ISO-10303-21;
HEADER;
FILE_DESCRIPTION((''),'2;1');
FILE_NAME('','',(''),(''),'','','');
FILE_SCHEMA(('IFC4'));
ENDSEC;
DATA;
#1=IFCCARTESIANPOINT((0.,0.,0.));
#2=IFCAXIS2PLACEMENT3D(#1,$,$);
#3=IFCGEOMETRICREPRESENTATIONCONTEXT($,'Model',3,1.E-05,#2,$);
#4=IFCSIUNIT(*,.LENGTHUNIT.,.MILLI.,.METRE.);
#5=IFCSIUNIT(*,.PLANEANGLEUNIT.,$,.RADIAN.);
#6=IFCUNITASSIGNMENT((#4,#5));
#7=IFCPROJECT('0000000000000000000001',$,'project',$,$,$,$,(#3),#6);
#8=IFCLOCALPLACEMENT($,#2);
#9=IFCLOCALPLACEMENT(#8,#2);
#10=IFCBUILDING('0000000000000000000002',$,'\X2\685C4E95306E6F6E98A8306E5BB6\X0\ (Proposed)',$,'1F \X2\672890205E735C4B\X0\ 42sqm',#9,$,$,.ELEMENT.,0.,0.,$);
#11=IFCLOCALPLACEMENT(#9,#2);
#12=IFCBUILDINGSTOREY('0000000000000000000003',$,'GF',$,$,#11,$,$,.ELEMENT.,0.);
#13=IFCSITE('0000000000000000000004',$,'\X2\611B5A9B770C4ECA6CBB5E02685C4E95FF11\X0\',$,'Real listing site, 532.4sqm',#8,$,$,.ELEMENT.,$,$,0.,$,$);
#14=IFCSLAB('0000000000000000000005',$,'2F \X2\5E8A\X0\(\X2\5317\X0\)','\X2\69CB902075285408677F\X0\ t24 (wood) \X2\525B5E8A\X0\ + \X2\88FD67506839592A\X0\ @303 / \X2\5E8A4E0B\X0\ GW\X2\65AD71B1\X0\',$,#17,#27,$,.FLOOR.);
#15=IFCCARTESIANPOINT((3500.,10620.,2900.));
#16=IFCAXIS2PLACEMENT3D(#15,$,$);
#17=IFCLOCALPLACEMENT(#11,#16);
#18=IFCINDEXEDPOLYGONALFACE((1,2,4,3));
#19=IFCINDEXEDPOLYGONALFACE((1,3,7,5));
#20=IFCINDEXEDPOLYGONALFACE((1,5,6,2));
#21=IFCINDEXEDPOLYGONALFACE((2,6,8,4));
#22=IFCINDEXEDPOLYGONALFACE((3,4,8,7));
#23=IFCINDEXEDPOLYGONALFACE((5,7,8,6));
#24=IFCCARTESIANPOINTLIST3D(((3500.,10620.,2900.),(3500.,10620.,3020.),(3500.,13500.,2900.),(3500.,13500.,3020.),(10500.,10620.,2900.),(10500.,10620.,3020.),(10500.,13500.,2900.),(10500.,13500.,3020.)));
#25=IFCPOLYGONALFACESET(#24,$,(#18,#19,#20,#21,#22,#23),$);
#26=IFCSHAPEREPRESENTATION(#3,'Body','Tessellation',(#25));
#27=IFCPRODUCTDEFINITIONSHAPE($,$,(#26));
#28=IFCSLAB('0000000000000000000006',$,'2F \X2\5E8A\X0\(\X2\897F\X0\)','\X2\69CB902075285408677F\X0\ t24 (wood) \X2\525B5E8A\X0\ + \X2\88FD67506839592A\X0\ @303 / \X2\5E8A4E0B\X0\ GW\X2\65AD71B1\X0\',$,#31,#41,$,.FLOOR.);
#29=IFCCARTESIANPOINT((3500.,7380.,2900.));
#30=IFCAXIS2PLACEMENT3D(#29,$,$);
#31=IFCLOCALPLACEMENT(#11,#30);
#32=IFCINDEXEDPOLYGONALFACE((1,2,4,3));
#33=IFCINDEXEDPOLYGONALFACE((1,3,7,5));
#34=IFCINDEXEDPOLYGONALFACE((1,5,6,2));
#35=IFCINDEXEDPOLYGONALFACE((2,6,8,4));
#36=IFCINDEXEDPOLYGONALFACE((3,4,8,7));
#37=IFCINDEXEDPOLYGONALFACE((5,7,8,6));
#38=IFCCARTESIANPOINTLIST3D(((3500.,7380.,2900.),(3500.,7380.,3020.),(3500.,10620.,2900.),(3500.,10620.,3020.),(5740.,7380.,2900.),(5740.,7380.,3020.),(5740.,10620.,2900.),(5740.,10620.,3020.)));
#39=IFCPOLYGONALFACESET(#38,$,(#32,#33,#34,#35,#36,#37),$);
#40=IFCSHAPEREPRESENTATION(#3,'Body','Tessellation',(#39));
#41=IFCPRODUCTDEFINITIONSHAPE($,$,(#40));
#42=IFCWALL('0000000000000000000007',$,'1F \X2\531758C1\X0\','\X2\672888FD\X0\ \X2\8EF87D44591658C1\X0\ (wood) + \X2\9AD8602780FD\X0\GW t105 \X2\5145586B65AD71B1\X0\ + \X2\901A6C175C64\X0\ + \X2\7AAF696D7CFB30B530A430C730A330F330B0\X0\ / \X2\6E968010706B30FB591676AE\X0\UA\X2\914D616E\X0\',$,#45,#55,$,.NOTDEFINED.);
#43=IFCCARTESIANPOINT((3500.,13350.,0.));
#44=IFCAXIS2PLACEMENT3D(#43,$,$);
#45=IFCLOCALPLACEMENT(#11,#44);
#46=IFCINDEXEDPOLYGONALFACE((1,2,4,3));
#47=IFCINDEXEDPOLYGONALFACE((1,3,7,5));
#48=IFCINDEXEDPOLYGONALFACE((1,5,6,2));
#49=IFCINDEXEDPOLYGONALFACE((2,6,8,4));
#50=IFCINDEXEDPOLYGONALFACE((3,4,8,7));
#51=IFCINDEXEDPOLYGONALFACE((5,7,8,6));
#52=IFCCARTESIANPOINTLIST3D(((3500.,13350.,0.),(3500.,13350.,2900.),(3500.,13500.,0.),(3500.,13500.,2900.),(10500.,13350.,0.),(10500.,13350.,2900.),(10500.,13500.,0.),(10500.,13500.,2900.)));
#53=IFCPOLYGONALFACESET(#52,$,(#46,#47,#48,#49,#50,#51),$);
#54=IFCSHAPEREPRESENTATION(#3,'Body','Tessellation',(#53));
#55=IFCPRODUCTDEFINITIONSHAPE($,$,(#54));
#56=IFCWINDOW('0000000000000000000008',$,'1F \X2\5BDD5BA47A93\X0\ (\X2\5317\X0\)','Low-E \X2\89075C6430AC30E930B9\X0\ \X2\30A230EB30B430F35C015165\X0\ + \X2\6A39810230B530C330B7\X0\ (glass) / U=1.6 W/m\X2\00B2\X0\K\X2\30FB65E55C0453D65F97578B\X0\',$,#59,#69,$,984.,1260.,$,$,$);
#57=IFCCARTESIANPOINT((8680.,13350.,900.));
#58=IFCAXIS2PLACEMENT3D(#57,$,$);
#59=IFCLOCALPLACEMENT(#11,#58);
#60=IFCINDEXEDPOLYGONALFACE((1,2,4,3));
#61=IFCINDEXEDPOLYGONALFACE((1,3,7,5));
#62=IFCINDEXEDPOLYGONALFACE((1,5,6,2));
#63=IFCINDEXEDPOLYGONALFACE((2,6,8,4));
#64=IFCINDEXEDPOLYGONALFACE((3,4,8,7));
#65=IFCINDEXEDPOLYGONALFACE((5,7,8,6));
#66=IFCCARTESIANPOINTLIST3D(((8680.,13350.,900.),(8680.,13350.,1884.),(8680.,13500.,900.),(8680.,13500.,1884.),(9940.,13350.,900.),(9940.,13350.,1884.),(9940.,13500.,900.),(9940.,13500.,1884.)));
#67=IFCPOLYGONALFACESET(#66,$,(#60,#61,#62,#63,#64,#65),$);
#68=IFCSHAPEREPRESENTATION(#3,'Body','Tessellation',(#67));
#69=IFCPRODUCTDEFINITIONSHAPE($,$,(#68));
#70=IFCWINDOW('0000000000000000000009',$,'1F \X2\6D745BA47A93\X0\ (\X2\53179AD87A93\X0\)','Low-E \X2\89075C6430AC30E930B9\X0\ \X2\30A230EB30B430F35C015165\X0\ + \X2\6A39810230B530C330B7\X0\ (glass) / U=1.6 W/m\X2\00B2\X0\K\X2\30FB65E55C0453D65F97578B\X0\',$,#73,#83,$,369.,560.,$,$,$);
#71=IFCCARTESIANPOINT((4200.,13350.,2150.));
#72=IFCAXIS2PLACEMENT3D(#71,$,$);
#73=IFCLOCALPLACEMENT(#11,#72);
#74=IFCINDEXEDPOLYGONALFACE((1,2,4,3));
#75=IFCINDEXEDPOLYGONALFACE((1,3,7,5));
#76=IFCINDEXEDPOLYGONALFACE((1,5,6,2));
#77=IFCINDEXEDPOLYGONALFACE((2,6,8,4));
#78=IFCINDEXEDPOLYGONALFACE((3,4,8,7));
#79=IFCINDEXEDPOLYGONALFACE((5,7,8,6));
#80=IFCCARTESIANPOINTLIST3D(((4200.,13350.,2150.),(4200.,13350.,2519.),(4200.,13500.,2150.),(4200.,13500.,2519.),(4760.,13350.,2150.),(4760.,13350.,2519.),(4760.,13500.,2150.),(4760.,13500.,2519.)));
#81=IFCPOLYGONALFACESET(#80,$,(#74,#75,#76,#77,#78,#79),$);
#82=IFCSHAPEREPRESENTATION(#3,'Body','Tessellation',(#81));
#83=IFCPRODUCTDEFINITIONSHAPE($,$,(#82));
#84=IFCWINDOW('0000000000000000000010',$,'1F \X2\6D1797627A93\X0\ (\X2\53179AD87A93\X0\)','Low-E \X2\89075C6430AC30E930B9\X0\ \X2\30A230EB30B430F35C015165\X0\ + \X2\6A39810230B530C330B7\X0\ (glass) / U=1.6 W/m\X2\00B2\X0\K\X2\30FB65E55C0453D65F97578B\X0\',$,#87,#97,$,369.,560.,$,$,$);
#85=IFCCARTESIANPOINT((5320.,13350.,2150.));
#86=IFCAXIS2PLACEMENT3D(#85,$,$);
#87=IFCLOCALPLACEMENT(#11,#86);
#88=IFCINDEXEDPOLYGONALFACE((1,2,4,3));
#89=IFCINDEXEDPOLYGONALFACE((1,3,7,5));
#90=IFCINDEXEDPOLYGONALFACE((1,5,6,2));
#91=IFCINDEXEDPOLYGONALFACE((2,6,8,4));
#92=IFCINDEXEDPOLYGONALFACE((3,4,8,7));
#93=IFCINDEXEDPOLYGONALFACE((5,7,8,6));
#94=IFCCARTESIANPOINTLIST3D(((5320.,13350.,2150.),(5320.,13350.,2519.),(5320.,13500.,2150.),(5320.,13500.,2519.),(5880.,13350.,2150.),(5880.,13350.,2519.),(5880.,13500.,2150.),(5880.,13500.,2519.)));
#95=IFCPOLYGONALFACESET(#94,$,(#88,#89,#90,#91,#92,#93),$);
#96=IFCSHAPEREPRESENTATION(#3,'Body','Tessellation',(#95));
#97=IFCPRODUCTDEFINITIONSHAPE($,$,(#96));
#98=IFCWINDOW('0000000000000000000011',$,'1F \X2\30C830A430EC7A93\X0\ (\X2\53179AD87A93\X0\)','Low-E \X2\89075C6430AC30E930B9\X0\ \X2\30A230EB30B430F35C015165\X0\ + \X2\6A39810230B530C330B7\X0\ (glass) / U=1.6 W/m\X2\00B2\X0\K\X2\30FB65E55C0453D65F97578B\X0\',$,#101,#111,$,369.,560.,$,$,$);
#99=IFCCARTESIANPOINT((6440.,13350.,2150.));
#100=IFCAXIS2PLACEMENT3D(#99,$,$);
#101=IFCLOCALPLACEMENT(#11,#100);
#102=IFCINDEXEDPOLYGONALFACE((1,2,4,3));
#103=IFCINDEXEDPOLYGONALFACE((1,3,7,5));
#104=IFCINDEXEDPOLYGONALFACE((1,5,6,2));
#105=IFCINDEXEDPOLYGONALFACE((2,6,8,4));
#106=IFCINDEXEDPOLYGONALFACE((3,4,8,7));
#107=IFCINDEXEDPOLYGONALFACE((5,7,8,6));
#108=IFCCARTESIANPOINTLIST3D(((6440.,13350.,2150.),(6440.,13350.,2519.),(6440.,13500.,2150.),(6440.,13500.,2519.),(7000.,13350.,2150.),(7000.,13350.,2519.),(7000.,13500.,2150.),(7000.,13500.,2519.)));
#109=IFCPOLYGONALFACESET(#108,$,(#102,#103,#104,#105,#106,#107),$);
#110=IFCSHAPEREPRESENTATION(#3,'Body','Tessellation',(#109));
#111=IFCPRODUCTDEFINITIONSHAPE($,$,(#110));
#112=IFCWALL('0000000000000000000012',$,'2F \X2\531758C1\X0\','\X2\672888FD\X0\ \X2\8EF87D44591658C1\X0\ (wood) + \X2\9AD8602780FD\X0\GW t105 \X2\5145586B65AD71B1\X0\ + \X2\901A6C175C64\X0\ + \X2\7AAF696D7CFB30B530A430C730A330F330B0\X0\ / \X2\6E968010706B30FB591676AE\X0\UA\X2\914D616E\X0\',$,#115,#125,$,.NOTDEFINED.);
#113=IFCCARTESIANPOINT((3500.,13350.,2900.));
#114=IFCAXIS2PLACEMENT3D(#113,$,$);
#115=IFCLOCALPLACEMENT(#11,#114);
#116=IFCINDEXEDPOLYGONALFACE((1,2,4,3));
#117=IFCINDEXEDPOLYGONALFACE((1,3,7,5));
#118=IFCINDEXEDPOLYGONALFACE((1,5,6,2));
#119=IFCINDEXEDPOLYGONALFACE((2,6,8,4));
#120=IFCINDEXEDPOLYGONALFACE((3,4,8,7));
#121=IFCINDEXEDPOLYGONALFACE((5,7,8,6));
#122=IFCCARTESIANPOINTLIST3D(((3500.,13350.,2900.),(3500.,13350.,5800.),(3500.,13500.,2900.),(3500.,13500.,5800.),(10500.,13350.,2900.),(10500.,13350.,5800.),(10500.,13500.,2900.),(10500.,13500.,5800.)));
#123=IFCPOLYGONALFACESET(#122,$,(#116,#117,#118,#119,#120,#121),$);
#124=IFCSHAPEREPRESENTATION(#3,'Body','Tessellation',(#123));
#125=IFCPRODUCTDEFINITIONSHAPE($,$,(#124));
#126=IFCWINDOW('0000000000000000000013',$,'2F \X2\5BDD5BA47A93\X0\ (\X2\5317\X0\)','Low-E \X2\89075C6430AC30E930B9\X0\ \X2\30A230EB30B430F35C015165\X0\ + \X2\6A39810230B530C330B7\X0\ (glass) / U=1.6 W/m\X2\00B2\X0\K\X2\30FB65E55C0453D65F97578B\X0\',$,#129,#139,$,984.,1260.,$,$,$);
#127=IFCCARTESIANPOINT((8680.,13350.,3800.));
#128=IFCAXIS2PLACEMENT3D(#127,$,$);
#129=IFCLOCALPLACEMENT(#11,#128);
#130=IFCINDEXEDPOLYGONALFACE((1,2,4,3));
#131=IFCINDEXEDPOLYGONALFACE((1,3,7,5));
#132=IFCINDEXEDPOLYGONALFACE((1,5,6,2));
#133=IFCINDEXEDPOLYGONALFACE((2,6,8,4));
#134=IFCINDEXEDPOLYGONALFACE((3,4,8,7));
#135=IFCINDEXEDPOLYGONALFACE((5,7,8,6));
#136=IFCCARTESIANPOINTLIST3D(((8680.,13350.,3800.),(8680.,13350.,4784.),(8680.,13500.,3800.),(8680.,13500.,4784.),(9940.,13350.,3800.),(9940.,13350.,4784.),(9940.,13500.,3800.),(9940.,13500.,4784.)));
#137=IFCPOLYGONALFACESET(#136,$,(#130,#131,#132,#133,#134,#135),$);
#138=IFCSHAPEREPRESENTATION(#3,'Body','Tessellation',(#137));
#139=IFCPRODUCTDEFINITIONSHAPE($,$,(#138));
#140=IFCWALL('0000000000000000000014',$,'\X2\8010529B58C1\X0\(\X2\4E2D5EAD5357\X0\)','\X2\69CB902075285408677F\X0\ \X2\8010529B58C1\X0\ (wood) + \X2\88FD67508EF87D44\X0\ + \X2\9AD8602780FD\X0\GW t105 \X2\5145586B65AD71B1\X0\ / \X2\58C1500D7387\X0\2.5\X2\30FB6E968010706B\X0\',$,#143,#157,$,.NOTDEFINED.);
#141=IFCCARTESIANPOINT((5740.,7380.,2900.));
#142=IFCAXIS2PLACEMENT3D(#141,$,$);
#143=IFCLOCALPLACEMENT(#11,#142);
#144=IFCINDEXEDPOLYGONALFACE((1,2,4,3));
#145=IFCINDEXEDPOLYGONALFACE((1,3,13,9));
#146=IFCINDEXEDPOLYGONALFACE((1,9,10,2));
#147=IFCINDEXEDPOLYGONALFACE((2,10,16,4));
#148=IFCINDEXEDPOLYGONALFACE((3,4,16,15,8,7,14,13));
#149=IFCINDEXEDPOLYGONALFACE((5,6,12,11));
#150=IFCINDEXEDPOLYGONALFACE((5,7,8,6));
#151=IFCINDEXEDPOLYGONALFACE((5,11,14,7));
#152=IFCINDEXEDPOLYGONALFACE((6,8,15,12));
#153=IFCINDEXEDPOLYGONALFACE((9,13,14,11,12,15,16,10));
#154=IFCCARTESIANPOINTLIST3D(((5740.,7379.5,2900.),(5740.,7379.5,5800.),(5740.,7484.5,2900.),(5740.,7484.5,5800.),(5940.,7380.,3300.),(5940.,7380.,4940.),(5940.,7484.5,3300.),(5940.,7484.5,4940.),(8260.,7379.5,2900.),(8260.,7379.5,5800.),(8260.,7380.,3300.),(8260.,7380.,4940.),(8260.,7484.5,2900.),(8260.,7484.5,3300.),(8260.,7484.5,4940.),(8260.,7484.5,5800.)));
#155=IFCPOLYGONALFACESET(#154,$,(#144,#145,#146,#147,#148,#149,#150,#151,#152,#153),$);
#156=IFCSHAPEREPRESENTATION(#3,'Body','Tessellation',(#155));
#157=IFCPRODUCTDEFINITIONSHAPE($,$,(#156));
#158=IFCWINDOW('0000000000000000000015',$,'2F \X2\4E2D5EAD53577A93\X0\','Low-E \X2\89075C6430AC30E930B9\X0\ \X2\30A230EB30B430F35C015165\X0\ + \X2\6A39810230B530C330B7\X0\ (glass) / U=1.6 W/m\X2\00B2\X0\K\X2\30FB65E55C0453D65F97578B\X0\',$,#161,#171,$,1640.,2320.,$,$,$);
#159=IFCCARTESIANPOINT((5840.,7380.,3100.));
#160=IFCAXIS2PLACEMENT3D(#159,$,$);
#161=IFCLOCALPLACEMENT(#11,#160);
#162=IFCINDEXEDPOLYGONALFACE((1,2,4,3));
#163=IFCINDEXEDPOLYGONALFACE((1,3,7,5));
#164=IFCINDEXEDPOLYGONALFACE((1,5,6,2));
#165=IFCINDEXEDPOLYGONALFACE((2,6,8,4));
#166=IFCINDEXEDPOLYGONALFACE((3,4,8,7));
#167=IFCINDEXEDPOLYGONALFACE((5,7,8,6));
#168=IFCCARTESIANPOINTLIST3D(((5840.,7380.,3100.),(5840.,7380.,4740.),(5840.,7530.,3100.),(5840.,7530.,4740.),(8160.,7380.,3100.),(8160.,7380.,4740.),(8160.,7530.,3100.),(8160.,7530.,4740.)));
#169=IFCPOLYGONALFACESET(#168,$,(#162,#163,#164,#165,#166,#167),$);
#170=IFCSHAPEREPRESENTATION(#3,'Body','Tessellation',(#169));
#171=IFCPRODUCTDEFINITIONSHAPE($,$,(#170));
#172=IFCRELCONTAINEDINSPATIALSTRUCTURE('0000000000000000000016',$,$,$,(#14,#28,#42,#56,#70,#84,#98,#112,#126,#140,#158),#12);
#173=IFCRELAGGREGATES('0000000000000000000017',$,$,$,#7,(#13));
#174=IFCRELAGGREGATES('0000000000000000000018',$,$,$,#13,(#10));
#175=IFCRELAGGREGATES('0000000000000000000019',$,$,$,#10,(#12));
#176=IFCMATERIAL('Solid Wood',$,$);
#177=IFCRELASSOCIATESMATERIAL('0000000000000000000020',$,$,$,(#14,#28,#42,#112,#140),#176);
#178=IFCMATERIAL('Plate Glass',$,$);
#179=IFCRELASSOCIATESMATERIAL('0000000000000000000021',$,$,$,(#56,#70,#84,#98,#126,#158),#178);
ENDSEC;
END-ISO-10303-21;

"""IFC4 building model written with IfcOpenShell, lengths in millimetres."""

from ifc_helpers import new_model, si_unit, frame, frame_2d, origin, place, context, project, spatial, rectangle, extrude, material, element, fill, save


model = new_model("IFC4")

# Units and contexts
model_context = context("Model", 3, precision=1e-05, world=origin())
ifc_project = project(units=[si_unit("LENGTHUNIT", "METRE", prefix="MILLI"), si_unit("PLANEANGLEUNIT", "RADIAN")], contexts=[model_context])

# Site, building, storey
site_placement = place(None, origin())
site = spatial("IfcSite", under=ifc_project, at=site_placement, Name="愛媛県今治市桜井１", ObjectType="Real listing site, 532.4sqm", CompositionType="ELEMENT", RefElevation=0.0)
building_placement = place(site_placement, origin())
building = spatial("IfcBuilding", under=site, at=building_placement, Name="桜井の潮風の家 (Proposed)", ObjectType="1F 木造平屋 42sqm", CompositionType="ELEMENT", ElevationOfRefHeight=0.0, ElevationOfTerrain=0.0)
storey_placement = place(building_placement, origin())
storey = spatial("IfcBuildingStorey", under=building, at=storey_placement, Name="GF", CompositionType="ELEMENT", Elevation=0.0)

# Slabs
ifc_material_1 = material(Name="Solid Wood")
slab_1_placement = place(storey_placement, frame((3500.0, 10620.0, 2900.0)))
element("IfcSlab", 1, at=slab_1_placement, inside=storey, material=ifc_material_1, Name="2F 床(北)", Description="構造用合板 t24 (wood) 剛床 + 製材根太 @303 / 床下 GW断熱", PredefinedType="FLOOR", context=model_context, shape_type="SweptSolid", body=[
    extrude(rectangle(XDim=7000.0, YDim=2880.0, at=frame_2d((3500.0, 1440.0))), frame((3500.0, 10620.0, 2900.0)), (0.0, 0.0, 1.0), 120.0),
])
slab_2_placement = place(storey_placement, frame((3500.0, 7380.0, 2900.0)))
element("IfcSlab", 2, at=slab_2_placement, inside=storey, material=ifc_material_1, Name="2F 床(西)", Description="構造用合板 t24 (wood) 剛床 + 製材根太 @303 / 床下 GW断熱", PredefinedType="FLOOR", context=model_context, shape_type="SweptSolid", body=[
    extrude(rectangle(XDim=2240.0, YDim=3240.0, at=frame_2d((1120.0, 1620.0))), frame((3500.0, 7380.0, 2900.0)), (0.0, 0.0, 1.0), 120.0),
])

# Wall, openings, windows
wall_1_placement = place(storey_placement, frame((3500.0, 13350.0, 0.0)))
wall_1 = element("IfcWall", 3, at=wall_1_placement, inside=storey, material=ifc_material_1, Name="1F 北壁", Description="木製 軸組外壁 (wood) + 高性能GW t105 充填断熱 + 通気層 + 窯業系サイディング / 準耐火・外皮UA配慮", PredefinedType="NOTDEFINED", context=model_context, shape_type="SweptSolid", body=[
    extrude(rectangle(XDim=7000.0, YDim=150.0, at=frame_2d((3500.0, 75.0))), frame((3500.0, 13350.0, 0.0)), (0.0, 0.0, 1.0), 2900.0),
])
opening_1_placement = place(storey_placement, frame((8680.0, 13350.0, 900.0)))
opening_1 = element("IfcOpeningElement", 4, at=opening_1_placement, cuts=wall_1, PredefinedType="NOTDEFINED", context=model_context, shape_type="SweptSolid", body=[
    extrude(rectangle(XDim=1260.0, YDim=150.0, at=frame_2d((630.0, 75.0))), frame((8680.0, 13350.0, 900.0)), (0.0, 0.0, 1.0), 984.0),
])
opening_2_placement = place(storey_placement, frame((4200.0, 13350.0, 2150.0)))
opening_2 = element("IfcOpeningElement", 5, at=opening_2_placement, cuts=wall_1, PredefinedType="NOTDEFINED", context=model_context, shape_type="SweptSolid", body=[
    extrude(rectangle(XDim=560.0, YDim=150.0, at=frame_2d((280.0, 75.0))), frame((4200.0, 13350.0, 2150.0)), (0.0, 0.0, 1.0), 369.0),
])
opening_3_placement = place(storey_placement, frame((5320.0, 13350.0, 2150.0)))
opening_3 = element("IfcOpeningElement", 6, at=opening_3_placement, cuts=wall_1, PredefinedType="NOTDEFINED", context=model_context, shape_type="SweptSolid", body=[
    extrude(rectangle(XDim=560.0, YDim=150.0, at=frame_2d((280.0, 75.0))), frame((5320.0, 13350.0, 2150.0)), (0.0, 0.0, 1.0), 369.0),
])
opening_4_placement = place(storey_placement, frame((6440.0, 13350.0, 2150.0)))
opening_4 = element("IfcOpeningElement", 7, at=opening_4_placement, cuts=wall_1, PredefinedType="NOTDEFINED", context=model_context, shape_type="SweptSolid", body=[
    extrude(rectangle(XDim=560.0, YDim=150.0, at=frame_2d((280.0, 75.0))), frame((6440.0, 13350.0, 2150.0)), (0.0, 0.0, 1.0), 369.0),
])
ifc_material_2 = material(Name="Plate Glass")
window_1_placement = place(storey_placement, frame((8680.0, 13350.0, 900.0)))
window_1 = element("IfcWindow", 8, at=window_1_placement, inside=storey, material=ifc_material_2, Name="1F 寝室窓 (北)", Description="Low-E 複層ガラス アルゴン封入 + 樹脂サッシ (glass) / U=1.6 W/m²K・日射取得型", OverallHeight=984.0, OverallWidth=1260.0, context=model_context, shape_type="SweptSolid", body=[
    extrude(rectangle(XDim=1260.0, YDim=150.0, at=frame_2d((630.0, 75.0))), frame((8680.0, 13350.0, 900.0)), (0.0, 0.0, 1.0), 984.0),
])
fill(opening_1, window_1)
window_2_placement = place(storey_placement, frame((4200.0, 13350.0, 2150.0)))
window_2 = element("IfcWindow", 9, at=window_2_placement, inside=storey, material=ifc_material_2, Name="1F 浴室窓 (北高窓)", Description="Low-E 複層ガラス アルゴン封入 + 樹脂サッシ (glass) / U=1.6 W/m²K・日射取得型", OverallHeight=369.0, OverallWidth=560.0, context=model_context, shape_type="SweptSolid", body=[
    extrude(rectangle(XDim=560.0, YDim=150.0, at=frame_2d((280.0, 75.0))), frame((4200.0, 13350.0, 2150.0)), (0.0, 0.0, 1.0), 369.0),
])
fill(opening_2, window_2)
window_3_placement = place(storey_placement, frame((5320.0, 13350.0, 2150.0)))
window_3 = element("IfcWindow", 10, at=window_3_placement, inside=storey, material=ifc_material_2, Name="1F 洗面窓 (北高窓)", Description="Low-E 複層ガラス アルゴン封入 + 樹脂サッシ (glass) / U=1.6 W/m²K・日射取得型", OverallHeight=369.0, OverallWidth=560.0, context=model_context, shape_type="SweptSolid", body=[
    extrude(rectangle(XDim=560.0, YDim=150.0, at=frame_2d((280.0, 75.0))), frame((5320.0, 13350.0, 2150.0)), (0.0, 0.0, 1.0), 369.0),
])
fill(opening_3, window_3)
window_4_placement = place(storey_placement, frame((6440.0, 13350.0, 2150.0)))
window_4 = element("IfcWindow", 11, at=window_4_placement, inside=storey, material=ifc_material_2, Name="1F トイレ窓 (北高窓)", Description="Low-E 複層ガラス アルゴン封入 + 樹脂サッシ (glass) / U=1.6 W/m²K・日射取得型", OverallHeight=369.0, OverallWidth=560.0, context=model_context, shape_type="SweptSolid", body=[
    extrude(rectangle(XDim=560.0, YDim=150.0, at=frame_2d((280.0, 75.0))), frame((6440.0, 13350.0, 2150.0)), (0.0, 0.0, 1.0), 369.0),
])
fill(opening_4, window_4)

# Walls, openings, windows
wall_2_placement = place(storey_placement, frame((3500.0, 13350.0, 2900.0)))
wall_2 = element("IfcWall", 12, at=wall_2_placement, inside=storey, material=ifc_material_1, Name="2F 北壁", Description="木製 軸組外壁 (wood) + 高性能GW t105 充填断熱 + 通気層 + 窯業系サイディング / 準耐火・外皮UA配慮", PredefinedType="NOTDEFINED", context=model_context, shape_type="SweptSolid", body=[
    extrude(rectangle(XDim=7000.0, YDim=150.0, at=frame_2d((3500.0, 75.0))), frame((3500.0, 13350.0, 2900.0)), (0.0, 0.0, 1.0), 2900.0),
])
opening_5_placement = place(storey_placement, frame((8680.0, 13350.0, 3800.0)))
opening_5 = element("IfcOpeningElement", 13, at=opening_5_placement, cuts=wall_2, PredefinedType="NOTDEFINED", context=model_context, shape_type="SweptSolid", body=[
    extrude(rectangle(XDim=1260.0, YDim=150.0, at=frame_2d((630.0, 75.0))), frame((8680.0, 13350.0, 3800.0)), (0.0, 0.0, 1.0), 984.0),
])
window_5_placement = place(storey_placement, frame((8680.0, 13350.0, 3800.0)))
window_5 = element("IfcWindow", 14, at=window_5_placement, inside=storey, material=ifc_material_2, Name="2F 寝室窓 (北)", Description="Low-E 複層ガラス アルゴン封入 + 樹脂サッシ (glass) / U=1.6 W/m²K・日射取得型", OverallHeight=984.0, OverallWidth=1260.0, context=model_context, shape_type="SweptSolid", body=[
    extrude(rectangle(XDim=1260.0, YDim=150.0, at=frame_2d((630.0, 75.0))), frame((8680.0, 13350.0, 3800.0)), (0.0, 0.0, 1.0), 984.0),
])
fill(opening_5, window_5)
wall_3_placement = place(storey_placement, frame((5740.0, 7380.0, 2900.0)))
wall_3 = element("IfcWall", 15, at=wall_3_placement, inside=storey, material=ifc_material_1, Name="耐力壁(中庭南)", Description="構造用合板 耐力壁 (wood) + 製材軸組 + 高性能GW t105 充填断熱 / 壁倍率2.5・準耐火", PredefinedType="NOTDEFINED", context=model_context, shape_type="SweptSolid", body=[
    extrude(rectangle(XDim=2520.0, YDim=105.0, at=frame_2d((1260.0, 52.0))), frame((5740.0, 7380.0, 2900.0)), (0.0, 0.0, 1.0), 2900.0),
])
opening_6_placement = place(storey_placement, frame((5840.0, 7380.0, 3100.0)))
opening_6 = element("IfcOpeningElement", 16, at=opening_6_placement, cuts=wall_3, PredefinedType="NOTDEFINED", context=model_context, shape_type="SweptSolid", body=[
    extrude(rectangle(XDim=2320.0, YDim=150.0, at=frame_2d((1160.0, 75.0))), frame((5840.0, 7380.0, 3100.0)), (0.0, 0.0, 1.0), 1640.0),
])
window_6_placement = place(storey_placement, frame((5840.0, 7380.0, 3100.0)))
window_6 = element("IfcWindow", 17, at=window_6_placement, inside=storey, material=ifc_material_2, Name="2F 中庭南窓", Description="Low-E 複層ガラス アルゴン封入 + 樹脂サッシ (glass) / U=1.6 W/m²K・日射取得型", OverallHeight=1640.0, OverallWidth=2320.0, context=model_context, shape_type="SweptSolid", body=[
    extrude(rectangle(XDim=2320.0, YDim=150.0, at=frame_2d((1160.0, 75.0))), frame((5840.0, 7380.0, 3100.0)), (0.0, 0.0, 1.0), 1640.0),
])
fill(opening_6, window_6)

save(model, "model.ifc")
